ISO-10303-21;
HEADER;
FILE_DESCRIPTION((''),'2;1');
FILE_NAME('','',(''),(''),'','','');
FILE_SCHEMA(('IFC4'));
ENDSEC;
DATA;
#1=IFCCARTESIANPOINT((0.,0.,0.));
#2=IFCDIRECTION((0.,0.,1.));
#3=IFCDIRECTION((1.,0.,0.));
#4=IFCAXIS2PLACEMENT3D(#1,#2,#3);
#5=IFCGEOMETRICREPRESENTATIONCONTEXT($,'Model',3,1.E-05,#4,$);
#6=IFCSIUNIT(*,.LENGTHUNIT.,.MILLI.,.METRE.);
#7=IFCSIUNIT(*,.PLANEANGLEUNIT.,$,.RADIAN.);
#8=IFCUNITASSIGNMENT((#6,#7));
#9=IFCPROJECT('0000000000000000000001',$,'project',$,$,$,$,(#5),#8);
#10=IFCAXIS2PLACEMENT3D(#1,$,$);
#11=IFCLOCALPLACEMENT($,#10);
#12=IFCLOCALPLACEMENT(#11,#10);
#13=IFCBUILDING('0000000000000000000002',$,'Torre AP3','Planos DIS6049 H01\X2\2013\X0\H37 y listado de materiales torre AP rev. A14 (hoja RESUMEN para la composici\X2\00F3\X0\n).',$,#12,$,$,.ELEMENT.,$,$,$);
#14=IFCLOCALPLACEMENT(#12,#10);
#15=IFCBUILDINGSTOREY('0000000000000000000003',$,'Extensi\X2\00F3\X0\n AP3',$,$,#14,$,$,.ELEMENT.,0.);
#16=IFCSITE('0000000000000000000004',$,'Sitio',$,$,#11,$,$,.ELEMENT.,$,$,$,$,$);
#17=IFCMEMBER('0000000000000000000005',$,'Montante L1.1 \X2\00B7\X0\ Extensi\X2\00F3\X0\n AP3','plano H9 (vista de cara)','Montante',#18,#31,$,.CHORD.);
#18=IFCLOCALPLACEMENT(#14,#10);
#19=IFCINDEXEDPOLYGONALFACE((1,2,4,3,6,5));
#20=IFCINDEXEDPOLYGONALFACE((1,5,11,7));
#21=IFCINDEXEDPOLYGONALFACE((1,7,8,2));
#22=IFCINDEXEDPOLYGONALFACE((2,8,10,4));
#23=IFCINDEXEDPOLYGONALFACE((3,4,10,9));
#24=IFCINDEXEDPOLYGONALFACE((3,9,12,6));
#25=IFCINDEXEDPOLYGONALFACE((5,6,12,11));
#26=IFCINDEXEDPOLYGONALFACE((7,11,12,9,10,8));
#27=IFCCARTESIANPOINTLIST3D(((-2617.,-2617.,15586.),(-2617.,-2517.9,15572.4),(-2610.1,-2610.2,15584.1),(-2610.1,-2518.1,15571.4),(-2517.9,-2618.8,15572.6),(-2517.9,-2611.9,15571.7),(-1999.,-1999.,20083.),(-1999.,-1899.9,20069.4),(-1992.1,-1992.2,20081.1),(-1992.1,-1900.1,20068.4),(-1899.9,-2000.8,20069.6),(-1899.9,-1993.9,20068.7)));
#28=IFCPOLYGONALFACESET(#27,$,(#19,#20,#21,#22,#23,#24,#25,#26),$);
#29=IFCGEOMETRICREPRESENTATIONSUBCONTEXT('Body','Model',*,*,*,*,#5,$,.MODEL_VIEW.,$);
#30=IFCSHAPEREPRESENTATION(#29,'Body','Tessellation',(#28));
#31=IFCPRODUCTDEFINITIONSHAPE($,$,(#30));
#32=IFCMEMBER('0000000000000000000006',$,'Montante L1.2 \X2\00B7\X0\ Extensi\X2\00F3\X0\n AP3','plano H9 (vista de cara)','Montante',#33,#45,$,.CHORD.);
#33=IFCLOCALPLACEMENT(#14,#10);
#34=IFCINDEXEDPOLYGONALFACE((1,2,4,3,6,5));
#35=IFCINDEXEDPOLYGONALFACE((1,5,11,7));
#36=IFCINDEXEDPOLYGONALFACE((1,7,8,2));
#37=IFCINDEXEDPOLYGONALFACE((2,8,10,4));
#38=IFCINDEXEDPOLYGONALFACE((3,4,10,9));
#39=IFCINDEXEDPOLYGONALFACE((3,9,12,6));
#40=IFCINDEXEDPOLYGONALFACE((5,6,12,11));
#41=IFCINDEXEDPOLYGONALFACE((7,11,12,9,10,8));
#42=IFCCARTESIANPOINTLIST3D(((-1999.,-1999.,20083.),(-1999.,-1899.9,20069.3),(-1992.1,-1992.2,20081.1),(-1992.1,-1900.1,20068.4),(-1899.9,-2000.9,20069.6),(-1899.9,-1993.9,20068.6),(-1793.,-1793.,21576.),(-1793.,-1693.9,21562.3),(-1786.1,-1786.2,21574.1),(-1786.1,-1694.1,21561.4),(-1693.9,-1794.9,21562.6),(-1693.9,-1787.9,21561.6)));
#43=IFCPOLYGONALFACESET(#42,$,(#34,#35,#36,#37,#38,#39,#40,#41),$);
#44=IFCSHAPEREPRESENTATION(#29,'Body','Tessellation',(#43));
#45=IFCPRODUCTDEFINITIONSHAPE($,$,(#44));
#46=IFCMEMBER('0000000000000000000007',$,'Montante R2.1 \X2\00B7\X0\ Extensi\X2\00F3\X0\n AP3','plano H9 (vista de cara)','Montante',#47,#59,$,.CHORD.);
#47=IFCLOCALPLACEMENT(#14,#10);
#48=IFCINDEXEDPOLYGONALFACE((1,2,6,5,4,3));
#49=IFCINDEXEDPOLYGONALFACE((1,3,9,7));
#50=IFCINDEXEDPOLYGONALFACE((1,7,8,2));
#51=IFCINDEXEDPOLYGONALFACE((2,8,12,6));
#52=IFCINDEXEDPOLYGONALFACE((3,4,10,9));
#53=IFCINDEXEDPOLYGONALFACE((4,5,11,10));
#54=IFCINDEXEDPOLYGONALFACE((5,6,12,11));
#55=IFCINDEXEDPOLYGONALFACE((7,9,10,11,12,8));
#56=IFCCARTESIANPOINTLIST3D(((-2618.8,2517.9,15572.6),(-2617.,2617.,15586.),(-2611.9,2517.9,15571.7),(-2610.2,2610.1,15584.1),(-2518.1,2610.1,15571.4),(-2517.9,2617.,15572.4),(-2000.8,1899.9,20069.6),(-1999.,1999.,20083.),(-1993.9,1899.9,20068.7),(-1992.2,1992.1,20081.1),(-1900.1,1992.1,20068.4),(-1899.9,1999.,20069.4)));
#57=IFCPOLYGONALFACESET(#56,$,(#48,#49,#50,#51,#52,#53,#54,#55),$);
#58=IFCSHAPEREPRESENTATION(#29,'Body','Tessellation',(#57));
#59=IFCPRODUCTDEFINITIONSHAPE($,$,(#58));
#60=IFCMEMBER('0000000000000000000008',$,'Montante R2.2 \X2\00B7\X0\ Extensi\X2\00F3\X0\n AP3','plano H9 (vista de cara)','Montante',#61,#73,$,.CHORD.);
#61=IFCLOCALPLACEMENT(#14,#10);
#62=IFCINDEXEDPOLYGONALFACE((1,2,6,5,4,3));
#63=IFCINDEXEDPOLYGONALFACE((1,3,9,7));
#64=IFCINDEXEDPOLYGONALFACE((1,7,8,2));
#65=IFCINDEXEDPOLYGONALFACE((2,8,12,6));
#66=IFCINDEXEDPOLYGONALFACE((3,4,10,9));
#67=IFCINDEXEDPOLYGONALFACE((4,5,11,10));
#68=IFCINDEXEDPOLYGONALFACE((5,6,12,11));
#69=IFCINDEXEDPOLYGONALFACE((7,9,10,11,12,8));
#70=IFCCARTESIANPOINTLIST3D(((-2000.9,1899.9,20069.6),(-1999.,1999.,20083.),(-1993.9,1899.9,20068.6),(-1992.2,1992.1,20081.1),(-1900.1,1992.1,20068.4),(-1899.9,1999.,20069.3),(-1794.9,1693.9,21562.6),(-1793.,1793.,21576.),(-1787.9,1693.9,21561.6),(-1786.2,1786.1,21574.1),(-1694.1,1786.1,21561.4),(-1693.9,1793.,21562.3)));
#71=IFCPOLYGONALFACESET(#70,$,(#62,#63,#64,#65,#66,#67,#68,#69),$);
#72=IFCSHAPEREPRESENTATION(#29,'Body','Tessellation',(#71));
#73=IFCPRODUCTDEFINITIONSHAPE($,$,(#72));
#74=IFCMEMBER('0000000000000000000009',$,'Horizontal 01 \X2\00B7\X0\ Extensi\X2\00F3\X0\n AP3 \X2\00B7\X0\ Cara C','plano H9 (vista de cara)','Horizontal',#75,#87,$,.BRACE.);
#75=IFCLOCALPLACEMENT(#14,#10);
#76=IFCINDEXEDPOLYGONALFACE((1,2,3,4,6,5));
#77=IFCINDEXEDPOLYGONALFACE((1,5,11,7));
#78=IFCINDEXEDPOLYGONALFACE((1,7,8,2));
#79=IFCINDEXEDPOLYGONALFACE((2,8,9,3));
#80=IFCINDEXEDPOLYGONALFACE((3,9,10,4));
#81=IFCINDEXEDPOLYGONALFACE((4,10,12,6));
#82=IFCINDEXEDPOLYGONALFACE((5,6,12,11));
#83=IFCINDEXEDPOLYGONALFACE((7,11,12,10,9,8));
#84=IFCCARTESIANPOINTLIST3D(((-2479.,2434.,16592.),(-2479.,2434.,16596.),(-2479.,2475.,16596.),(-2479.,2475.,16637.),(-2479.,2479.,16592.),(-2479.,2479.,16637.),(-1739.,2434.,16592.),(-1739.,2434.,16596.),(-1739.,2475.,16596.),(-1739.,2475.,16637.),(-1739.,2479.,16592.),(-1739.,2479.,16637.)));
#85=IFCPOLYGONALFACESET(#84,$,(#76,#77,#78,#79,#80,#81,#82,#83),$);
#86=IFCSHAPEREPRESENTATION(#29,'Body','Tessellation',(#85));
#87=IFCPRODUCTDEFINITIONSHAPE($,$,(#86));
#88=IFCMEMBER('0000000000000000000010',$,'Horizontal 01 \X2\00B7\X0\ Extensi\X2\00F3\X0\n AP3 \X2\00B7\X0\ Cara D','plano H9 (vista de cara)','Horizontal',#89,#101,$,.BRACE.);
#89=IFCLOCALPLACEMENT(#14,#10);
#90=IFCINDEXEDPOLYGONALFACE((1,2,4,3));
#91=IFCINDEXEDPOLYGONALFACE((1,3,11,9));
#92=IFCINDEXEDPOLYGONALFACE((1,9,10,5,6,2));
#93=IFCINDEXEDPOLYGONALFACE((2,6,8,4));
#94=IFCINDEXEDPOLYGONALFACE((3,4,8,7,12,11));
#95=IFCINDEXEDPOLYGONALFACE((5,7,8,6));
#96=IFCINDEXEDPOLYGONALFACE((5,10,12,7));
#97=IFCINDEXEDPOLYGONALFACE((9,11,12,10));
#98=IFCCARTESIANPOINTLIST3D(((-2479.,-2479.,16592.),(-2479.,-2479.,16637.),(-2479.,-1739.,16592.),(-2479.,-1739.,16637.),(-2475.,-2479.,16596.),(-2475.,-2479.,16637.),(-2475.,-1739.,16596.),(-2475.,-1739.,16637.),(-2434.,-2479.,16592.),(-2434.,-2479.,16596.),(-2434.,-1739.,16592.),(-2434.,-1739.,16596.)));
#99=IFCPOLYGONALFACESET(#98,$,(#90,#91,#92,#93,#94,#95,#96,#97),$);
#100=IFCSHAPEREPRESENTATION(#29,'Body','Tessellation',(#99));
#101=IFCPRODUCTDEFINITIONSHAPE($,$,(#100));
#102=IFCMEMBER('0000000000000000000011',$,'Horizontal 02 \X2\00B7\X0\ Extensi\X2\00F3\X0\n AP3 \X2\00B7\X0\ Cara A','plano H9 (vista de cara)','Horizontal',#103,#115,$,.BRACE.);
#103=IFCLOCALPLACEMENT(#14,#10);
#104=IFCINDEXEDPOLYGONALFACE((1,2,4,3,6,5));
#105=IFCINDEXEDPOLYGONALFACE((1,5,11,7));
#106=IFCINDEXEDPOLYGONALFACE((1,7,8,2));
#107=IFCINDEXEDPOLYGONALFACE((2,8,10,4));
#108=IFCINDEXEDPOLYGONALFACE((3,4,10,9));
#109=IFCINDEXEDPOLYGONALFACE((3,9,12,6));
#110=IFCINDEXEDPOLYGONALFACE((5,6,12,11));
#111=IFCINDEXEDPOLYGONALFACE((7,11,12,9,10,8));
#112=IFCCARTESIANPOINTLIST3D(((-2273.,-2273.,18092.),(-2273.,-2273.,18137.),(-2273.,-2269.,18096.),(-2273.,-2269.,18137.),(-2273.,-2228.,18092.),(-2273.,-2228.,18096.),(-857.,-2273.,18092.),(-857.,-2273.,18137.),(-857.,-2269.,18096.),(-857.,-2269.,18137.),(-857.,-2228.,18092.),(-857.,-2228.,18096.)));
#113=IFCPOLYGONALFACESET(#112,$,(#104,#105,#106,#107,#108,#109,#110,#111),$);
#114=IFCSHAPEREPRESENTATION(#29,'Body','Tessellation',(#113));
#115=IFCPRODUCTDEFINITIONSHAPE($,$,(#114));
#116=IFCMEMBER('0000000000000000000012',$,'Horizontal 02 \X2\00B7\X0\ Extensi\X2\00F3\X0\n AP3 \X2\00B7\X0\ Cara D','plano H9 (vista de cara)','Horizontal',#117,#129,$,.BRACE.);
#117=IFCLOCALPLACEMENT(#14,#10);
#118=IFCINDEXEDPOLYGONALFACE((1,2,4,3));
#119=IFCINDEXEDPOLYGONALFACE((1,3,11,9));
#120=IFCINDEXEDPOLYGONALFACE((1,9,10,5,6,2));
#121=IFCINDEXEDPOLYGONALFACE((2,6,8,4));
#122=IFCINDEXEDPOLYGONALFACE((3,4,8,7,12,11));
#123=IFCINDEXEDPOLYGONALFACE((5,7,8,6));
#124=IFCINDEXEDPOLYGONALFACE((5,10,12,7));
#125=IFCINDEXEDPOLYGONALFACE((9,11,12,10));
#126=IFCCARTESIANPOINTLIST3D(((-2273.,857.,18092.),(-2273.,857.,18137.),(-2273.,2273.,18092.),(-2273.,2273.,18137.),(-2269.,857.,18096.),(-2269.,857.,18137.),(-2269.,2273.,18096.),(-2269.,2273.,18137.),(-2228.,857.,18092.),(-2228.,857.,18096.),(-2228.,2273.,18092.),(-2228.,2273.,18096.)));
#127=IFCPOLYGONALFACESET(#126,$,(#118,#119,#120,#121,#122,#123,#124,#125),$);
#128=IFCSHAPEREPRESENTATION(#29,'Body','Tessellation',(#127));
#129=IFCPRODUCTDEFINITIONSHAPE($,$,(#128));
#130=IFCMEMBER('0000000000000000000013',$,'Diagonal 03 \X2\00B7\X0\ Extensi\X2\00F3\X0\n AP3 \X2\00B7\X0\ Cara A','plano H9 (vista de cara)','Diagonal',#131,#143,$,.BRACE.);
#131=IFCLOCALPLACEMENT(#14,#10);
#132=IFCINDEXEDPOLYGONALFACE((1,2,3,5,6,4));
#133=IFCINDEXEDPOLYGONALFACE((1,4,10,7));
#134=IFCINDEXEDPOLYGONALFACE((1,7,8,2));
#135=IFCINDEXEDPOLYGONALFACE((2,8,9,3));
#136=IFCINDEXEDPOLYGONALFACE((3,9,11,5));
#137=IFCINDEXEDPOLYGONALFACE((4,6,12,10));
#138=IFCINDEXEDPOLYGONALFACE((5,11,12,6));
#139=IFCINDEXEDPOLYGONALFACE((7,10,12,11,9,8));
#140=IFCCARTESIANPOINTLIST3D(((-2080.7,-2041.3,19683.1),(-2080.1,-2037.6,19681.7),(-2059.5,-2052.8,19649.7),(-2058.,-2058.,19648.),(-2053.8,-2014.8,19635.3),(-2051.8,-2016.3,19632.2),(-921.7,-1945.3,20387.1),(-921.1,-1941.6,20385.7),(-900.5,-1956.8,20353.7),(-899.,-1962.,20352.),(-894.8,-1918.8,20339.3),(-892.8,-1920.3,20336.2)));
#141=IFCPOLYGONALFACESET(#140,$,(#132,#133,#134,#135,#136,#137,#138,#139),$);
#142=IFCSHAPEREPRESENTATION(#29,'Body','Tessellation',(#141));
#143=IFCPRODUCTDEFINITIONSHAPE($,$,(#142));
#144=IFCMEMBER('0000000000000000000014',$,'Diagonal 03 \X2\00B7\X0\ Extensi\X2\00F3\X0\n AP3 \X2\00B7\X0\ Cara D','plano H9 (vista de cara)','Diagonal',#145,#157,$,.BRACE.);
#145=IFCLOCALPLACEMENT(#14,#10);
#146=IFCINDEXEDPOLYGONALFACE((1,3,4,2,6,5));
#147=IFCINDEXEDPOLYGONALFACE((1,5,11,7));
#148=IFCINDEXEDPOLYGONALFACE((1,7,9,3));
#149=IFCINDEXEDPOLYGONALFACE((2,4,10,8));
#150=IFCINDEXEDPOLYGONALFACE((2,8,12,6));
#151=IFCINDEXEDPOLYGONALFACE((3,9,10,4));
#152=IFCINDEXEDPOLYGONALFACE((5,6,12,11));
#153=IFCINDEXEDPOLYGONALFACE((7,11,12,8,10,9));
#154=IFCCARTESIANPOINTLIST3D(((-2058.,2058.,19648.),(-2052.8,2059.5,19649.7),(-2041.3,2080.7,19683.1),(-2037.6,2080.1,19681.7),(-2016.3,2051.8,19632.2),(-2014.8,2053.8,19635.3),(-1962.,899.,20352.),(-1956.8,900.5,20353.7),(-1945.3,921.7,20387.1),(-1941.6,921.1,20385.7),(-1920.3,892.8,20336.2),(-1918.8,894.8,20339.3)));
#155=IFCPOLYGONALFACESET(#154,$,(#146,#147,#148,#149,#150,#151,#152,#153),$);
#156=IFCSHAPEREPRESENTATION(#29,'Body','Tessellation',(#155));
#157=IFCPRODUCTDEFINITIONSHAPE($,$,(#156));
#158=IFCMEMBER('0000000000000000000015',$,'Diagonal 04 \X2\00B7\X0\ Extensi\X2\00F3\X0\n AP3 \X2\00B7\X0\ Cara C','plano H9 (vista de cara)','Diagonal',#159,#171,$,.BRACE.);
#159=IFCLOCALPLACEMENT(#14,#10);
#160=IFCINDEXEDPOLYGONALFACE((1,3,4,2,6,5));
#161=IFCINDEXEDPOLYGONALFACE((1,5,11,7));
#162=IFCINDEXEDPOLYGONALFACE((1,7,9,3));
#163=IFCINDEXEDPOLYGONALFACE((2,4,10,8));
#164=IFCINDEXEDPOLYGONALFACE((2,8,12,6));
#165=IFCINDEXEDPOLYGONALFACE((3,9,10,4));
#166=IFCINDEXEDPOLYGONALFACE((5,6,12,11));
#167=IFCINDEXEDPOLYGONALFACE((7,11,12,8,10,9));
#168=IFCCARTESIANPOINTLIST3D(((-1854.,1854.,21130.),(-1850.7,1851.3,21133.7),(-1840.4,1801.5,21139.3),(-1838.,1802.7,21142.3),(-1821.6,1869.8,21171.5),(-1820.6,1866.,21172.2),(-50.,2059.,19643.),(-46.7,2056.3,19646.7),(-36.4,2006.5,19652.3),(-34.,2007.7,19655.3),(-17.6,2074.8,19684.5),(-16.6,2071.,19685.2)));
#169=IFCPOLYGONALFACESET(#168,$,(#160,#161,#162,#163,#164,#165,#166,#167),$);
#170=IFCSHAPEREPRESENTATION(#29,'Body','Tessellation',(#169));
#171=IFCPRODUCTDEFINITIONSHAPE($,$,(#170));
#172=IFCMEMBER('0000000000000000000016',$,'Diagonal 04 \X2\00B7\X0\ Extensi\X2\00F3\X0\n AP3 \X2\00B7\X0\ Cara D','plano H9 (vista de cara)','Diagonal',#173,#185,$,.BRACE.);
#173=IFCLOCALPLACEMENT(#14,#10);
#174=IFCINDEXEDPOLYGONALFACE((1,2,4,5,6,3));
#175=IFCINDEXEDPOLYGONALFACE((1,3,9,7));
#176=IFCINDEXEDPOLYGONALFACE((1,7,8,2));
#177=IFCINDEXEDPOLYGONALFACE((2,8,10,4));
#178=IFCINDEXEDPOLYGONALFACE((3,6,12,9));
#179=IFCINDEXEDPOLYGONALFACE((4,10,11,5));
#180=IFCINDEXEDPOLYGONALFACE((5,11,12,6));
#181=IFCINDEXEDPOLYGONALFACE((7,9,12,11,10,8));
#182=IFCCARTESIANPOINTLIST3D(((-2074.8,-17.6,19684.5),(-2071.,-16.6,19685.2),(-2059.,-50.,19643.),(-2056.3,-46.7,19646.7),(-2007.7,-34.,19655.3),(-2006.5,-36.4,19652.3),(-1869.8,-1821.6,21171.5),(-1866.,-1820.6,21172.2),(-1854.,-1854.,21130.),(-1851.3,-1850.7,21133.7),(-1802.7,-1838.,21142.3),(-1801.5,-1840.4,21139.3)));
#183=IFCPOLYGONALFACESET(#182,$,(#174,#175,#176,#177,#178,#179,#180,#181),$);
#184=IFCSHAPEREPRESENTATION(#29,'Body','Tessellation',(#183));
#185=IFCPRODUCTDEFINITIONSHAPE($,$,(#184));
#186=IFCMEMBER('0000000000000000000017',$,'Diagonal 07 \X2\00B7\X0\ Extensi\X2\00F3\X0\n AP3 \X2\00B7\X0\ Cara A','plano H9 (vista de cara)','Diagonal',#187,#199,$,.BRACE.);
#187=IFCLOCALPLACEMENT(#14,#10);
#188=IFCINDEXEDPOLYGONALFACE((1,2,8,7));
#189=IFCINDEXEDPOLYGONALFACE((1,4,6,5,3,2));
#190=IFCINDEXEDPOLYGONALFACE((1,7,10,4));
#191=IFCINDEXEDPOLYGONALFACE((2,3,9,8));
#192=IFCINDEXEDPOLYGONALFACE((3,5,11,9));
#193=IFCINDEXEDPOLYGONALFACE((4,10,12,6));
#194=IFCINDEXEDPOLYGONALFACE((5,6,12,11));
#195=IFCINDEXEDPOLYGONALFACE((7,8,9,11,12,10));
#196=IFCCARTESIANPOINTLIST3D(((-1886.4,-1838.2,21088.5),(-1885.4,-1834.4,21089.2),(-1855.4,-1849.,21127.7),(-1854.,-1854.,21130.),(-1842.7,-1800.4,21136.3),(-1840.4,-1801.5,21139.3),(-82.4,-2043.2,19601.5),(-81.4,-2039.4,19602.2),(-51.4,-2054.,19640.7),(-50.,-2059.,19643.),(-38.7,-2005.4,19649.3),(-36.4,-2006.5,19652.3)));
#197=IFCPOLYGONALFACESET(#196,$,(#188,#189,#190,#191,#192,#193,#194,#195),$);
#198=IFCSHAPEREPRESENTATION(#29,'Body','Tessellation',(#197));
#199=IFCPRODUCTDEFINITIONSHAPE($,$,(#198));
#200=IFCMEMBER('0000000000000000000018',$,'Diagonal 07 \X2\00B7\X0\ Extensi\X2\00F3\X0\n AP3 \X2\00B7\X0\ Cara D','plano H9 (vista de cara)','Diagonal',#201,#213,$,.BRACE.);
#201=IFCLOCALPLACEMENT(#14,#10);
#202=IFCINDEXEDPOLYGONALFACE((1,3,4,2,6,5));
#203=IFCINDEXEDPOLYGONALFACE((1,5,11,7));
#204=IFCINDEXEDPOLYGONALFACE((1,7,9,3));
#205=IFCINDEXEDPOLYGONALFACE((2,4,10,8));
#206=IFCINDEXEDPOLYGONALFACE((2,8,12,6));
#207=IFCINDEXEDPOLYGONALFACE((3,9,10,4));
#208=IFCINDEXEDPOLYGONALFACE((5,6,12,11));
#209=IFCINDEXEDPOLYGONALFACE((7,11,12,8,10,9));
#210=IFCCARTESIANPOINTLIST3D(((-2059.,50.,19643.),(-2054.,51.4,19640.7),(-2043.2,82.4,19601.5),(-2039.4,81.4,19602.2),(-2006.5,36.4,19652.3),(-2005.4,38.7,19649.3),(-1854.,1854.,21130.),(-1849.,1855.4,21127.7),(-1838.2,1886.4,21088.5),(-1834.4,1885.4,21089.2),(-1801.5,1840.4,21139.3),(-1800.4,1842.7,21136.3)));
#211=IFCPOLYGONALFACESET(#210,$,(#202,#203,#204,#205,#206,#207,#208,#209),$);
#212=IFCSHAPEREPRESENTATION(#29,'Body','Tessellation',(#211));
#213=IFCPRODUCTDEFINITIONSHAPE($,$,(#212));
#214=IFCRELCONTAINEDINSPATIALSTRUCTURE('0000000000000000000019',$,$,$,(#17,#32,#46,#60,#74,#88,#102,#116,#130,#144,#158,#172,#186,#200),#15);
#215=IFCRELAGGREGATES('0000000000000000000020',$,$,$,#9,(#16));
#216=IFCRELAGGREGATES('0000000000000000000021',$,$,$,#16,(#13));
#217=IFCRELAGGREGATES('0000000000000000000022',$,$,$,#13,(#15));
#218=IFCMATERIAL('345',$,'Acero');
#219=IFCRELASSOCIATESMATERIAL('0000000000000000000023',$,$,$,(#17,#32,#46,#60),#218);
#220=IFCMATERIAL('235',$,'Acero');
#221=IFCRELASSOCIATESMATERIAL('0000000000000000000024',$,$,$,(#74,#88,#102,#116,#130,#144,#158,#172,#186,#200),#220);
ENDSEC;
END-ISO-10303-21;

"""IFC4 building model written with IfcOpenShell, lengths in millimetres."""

from ifc_helpers import new_model, si_unit, frame, frame_2d, origin, origin_with_axes, place, context, subcontext, project, spatial, l_section, extrude, material, element, save


model = new_model("IFC4")

# Units and contexts
model_context = context("Model", 3, precision=1e-05, world=origin_with_axes())
body_context = subcontext(model_context, "Body", "Model", "MODEL_VIEW")
ifc_project = project(units=[si_unit("LENGTHUNIT", "METRE", prefix="MILLI"), si_unit("PLANEANGLEUNIT", "RADIAN")], contexts=[model_context])

# Site, building, storey
site_placement = place(None, origin())
site = spatial("IfcSite", under=ifc_project, at=site_placement, Name="Sitio", CompositionType="ELEMENT")
building_placement = place(site_placement, origin())
building = spatial("IfcBuilding", under=site, at=building_placement, Name="Torre AP3", Description="Planos DIS6049 H01–H37 y listado de materiales torre AP rev. A14 (hoja RESUMEN para la composición).", CompositionType="ELEMENT")
storey_placement = place(building_placement, origin())
storey = spatial("IfcBuildingStorey", under=building, at=storey_placement, Name="Extensión AP3", CompositionType="ELEMENT", Elevation=0.0)

# Members
ifc_material_1 = material(Name="345", Category="Acero")
member_1_placement = place(storey_placement, frame((-2617.0, -2617.0, 15586.0), z_axis=(0.134901, 0.134901, 0.981633), x_axis=(0.990859, -0.018366, -0.133645)))
element("IfcMember", 1, at=member_1_placement, inside=storey, material=ifc_material_1, Name="Montante L1.1 · Extensión AP3", Description="plano H9 (vista de cara)", ObjectType="Montante", PredefinedType="CHORD", context=body_context, shape_type="SweptSolid", body=[
    extrude(l_section(Depth=100.0, Width=100.0, Thickness=7.0, at=frame_2d((50.0, 50.0))), None, (0.0, 0.0, 1.0), 4581.1),
])
member_2_placement = place(storey_placement, frame((-1999.0, -1999.0, 20083.0), z_axis=(0.135423, 0.135423, 0.981489), x_axis=(0.990788, -0.01851, -0.134152)))
element("IfcMember", 2, at=member_2_placement, inside=storey, material=ifc_material_1, Name="Montante L1.2 · Extensión AP3", Description="plano H9 (vista de cara)", ObjectType="Montante", PredefinedType="CHORD", context=body_context, shape_type="SweptSolid", body=[
    extrude(l_section(Depth=100.0, Width=100.0, Thickness=7.0, at=frame_2d((50.0, 50.0))), None, (0.0, 0.0, 1.0), 1521.2),
])
member_3_placement = place(storey_placement, frame((-2617.0, 2617.0, 15586.0), z_axis=(0.134901, -0.134901, 0.981633), x_axis=(-0.018366, -0.990859, -0.133645)))
element("IfcMember", 3, at=member_3_placement, inside=storey, material=ifc_material_1, Name="Montante R2.1 · Extensión AP3", Description="plano H9 (vista de cara)", ObjectType="Montante", PredefinedType="CHORD", context=body_context, shape_type="SweptSolid", body=[
    extrude(l_section(Depth=100.0, Width=100.0, Thickness=7.0, at=frame_2d((50.0, 50.0))), None, (0.0, 0.0, 1.0), 4581.1),
])
member_4_placement = place(storey_placement, frame((-1999.0, 1999.0, 20083.0), z_axis=(0.135423, -0.135423, 0.981489), x_axis=(-0.01851, -0.990788, -0.134152)))
element("IfcMember", 4, at=member_4_placement, inside=storey, material=ifc_material_1, Name="Montante R2.2 · Extensión AP3", Description="plano H9 (vista de cara)", ObjectType="Montante", PredefinedType="CHORD", context=body_context, shape_type="SweptSolid", body=[
    extrude(l_section(Depth=100.0, Width=100.0, Thickness=7.0, at=frame_2d((50.0, 50.0))), None, (0.0, 0.0, 1.0), 1521.2),
])
ifc_material_2 = material(Name="235", Category="Acero")
for number, where, z_axis, x_axis, name in (
    (5, (-1739.0, 2479.0, 16592.0), (-1.0, 0.0, 0.0), (0.0, -1.0, 0.0), "Horizontal 01 · Extensión AP3 · Cara C"),
    (6, (-2479.0, -1739.0, 16592.0), (0.0, -1.0, 0.0), (1.0, 0.0, 0.0), "Horizontal 01 · Extensión AP3 · Cara D"),
):
    element("IfcMember", number, at=place(storey_placement, frame(where, z_axis=z_axis, x_axis=x_axis)), inside=storey, material=ifc_material_2, Name=name, Description="plano H9 (vista de cara)", ObjectType="Horizontal", PredefinedType="BRACE", context=body_context, shape_type="SweptSolid", body=[
        extrude(l_section(Depth=45.0, Width=45.0, Thickness=4.0, at=frame_2d((22.5, 22.5))), None, (0.0, 0.0, 1.0), 740.0),
    ])
for number, where, z_axis, x_axis, name in (
    (7, (-2273.0, -2273.0, 18092.0), (1.0, 0.0, 0.0), (0.0, 1.0, 0.0), "Horizontal 02 · Extensión AP3 · Cara A"),
    (8, (-2273.0, 2273.0, 18092.0), (0.0, -1.0, 0.0), (1.0, 0.0, 0.0), "Horizontal 02 · Extensión AP3 · Cara D"),
):
    element("IfcMember", number, at=place(storey_placement, frame(where, z_axis=z_axis, x_axis=x_axis)), inside=storey, material=ifc_material_2, Name=name, Description="plano H9 (vista de cara)", ObjectType="Horizontal", PredefinedType="BRACE", context=body_context, shape_type="SweptSolid", body=[
        extrude(l_section(Depth=45.0, Width=45.0, Thickness=4.0, at=frame_2d((22.5, 22.5))), None, (0.0, 0.0, 1.0), 1416.0),
    ])
for number, where, z_axis, x_axis, name in (
    (9, (-2058.0, -2058.0, 19648.0), (0.852549, 0.070617, 0.517855), (0.137057, 0.925948, -0.351904), "Diagonal 03 · Extensión AP3 · Cara A"),
    (10, (-2058.0, 2058.0, 19648.0), (0.070617, -0.852549, 0.517855), (0.925948, -0.137057, -0.351904), "Diagonal 03 · Extensión AP3 · Cara D"),
):
    element("IfcMember", number, at=place(storey_placement, frame(where, z_axis=z_axis, x_axis=x_axis)), inside=storey, material=ifc_material_2, Name=name, Description="plano H9 (vista de cara)", ObjectType="Diagonal", PredefinedType="BRACE", context=body_context, shape_type="SweptSolid", body=[
        extrude(l_section(Depth=45.0, Width=45.0, Thickness=4.0, at=frame_2d((22.5, 22.5))), None, (0.0, 0.0, 1.0), 1359.5),
    ])
for number, where, z_axis, x_axis, name in (
    (11, (-50.0, 2059.0, 19643.0), (-0.768697, -0.087352, 0.633621), (0.247751, -0.953961, 0.169052), "Diagonal 04 · Extensión AP3 · Cara C"),
    (12, (-2059.0, -50.0, 19643.0), (0.087352, -0.768697, 0.633621), (0.953961, 0.247751, 0.169052), "Diagonal 04 · Extensión AP3 · Cara D"),
):
    element("IfcMember", number, at=place(storey_placement, frame(where, z_axis=z_axis, x_axis=x_axis)), inside=storey, material=ifc_material_2, Name=name, Description="plano H9 (vista de cara)", ObjectType="Diagonal", PredefinedType="BRACE", context=body_context, shape_type="SweptSolid", body=[
        extrude(l_section(Depth=55.0, Width=55.0, Thickness=4.0, at=frame_2d((27.5, 27.5))), None, (0.0, 0.0, 1.0), 2346.8),
    ])
for number, where, z_axis, x_axis, name in (
    (13, (-50.0, -2059.0, 19643.0), (-0.768697, 0.087352, 0.633621), (0.247751, 0.953961, 0.169052), "Diagonal 07 · Extensión AP3 · Cara A"),
    (14, (-2059.0, 50.0, 19643.0), (0.087352, 0.768697, 0.633621), (0.953961, -0.247751, 0.169052), "Diagonal 07 · Extensión AP3 · Cara D"),
):
    element("IfcMember", number, at=place(storey_placement, frame(where, z_axis=z_axis, x_axis=x_axis)), inside=storey, material=ifc_material_2, Name=name, Description="plano H9 (vista de cara)", ObjectType="Diagonal", PredefinedType="BRACE", context=body_context, shape_type="SweptSolid", body=[
        extrude(l_section(Depth=55.0, Width=55.0, Thickness=4.0, at=frame_2d((27.5, 27.5))), None, (0.0, 0.0, 1.0), 2346.8),
    ])

save(model, "model.ifc")
